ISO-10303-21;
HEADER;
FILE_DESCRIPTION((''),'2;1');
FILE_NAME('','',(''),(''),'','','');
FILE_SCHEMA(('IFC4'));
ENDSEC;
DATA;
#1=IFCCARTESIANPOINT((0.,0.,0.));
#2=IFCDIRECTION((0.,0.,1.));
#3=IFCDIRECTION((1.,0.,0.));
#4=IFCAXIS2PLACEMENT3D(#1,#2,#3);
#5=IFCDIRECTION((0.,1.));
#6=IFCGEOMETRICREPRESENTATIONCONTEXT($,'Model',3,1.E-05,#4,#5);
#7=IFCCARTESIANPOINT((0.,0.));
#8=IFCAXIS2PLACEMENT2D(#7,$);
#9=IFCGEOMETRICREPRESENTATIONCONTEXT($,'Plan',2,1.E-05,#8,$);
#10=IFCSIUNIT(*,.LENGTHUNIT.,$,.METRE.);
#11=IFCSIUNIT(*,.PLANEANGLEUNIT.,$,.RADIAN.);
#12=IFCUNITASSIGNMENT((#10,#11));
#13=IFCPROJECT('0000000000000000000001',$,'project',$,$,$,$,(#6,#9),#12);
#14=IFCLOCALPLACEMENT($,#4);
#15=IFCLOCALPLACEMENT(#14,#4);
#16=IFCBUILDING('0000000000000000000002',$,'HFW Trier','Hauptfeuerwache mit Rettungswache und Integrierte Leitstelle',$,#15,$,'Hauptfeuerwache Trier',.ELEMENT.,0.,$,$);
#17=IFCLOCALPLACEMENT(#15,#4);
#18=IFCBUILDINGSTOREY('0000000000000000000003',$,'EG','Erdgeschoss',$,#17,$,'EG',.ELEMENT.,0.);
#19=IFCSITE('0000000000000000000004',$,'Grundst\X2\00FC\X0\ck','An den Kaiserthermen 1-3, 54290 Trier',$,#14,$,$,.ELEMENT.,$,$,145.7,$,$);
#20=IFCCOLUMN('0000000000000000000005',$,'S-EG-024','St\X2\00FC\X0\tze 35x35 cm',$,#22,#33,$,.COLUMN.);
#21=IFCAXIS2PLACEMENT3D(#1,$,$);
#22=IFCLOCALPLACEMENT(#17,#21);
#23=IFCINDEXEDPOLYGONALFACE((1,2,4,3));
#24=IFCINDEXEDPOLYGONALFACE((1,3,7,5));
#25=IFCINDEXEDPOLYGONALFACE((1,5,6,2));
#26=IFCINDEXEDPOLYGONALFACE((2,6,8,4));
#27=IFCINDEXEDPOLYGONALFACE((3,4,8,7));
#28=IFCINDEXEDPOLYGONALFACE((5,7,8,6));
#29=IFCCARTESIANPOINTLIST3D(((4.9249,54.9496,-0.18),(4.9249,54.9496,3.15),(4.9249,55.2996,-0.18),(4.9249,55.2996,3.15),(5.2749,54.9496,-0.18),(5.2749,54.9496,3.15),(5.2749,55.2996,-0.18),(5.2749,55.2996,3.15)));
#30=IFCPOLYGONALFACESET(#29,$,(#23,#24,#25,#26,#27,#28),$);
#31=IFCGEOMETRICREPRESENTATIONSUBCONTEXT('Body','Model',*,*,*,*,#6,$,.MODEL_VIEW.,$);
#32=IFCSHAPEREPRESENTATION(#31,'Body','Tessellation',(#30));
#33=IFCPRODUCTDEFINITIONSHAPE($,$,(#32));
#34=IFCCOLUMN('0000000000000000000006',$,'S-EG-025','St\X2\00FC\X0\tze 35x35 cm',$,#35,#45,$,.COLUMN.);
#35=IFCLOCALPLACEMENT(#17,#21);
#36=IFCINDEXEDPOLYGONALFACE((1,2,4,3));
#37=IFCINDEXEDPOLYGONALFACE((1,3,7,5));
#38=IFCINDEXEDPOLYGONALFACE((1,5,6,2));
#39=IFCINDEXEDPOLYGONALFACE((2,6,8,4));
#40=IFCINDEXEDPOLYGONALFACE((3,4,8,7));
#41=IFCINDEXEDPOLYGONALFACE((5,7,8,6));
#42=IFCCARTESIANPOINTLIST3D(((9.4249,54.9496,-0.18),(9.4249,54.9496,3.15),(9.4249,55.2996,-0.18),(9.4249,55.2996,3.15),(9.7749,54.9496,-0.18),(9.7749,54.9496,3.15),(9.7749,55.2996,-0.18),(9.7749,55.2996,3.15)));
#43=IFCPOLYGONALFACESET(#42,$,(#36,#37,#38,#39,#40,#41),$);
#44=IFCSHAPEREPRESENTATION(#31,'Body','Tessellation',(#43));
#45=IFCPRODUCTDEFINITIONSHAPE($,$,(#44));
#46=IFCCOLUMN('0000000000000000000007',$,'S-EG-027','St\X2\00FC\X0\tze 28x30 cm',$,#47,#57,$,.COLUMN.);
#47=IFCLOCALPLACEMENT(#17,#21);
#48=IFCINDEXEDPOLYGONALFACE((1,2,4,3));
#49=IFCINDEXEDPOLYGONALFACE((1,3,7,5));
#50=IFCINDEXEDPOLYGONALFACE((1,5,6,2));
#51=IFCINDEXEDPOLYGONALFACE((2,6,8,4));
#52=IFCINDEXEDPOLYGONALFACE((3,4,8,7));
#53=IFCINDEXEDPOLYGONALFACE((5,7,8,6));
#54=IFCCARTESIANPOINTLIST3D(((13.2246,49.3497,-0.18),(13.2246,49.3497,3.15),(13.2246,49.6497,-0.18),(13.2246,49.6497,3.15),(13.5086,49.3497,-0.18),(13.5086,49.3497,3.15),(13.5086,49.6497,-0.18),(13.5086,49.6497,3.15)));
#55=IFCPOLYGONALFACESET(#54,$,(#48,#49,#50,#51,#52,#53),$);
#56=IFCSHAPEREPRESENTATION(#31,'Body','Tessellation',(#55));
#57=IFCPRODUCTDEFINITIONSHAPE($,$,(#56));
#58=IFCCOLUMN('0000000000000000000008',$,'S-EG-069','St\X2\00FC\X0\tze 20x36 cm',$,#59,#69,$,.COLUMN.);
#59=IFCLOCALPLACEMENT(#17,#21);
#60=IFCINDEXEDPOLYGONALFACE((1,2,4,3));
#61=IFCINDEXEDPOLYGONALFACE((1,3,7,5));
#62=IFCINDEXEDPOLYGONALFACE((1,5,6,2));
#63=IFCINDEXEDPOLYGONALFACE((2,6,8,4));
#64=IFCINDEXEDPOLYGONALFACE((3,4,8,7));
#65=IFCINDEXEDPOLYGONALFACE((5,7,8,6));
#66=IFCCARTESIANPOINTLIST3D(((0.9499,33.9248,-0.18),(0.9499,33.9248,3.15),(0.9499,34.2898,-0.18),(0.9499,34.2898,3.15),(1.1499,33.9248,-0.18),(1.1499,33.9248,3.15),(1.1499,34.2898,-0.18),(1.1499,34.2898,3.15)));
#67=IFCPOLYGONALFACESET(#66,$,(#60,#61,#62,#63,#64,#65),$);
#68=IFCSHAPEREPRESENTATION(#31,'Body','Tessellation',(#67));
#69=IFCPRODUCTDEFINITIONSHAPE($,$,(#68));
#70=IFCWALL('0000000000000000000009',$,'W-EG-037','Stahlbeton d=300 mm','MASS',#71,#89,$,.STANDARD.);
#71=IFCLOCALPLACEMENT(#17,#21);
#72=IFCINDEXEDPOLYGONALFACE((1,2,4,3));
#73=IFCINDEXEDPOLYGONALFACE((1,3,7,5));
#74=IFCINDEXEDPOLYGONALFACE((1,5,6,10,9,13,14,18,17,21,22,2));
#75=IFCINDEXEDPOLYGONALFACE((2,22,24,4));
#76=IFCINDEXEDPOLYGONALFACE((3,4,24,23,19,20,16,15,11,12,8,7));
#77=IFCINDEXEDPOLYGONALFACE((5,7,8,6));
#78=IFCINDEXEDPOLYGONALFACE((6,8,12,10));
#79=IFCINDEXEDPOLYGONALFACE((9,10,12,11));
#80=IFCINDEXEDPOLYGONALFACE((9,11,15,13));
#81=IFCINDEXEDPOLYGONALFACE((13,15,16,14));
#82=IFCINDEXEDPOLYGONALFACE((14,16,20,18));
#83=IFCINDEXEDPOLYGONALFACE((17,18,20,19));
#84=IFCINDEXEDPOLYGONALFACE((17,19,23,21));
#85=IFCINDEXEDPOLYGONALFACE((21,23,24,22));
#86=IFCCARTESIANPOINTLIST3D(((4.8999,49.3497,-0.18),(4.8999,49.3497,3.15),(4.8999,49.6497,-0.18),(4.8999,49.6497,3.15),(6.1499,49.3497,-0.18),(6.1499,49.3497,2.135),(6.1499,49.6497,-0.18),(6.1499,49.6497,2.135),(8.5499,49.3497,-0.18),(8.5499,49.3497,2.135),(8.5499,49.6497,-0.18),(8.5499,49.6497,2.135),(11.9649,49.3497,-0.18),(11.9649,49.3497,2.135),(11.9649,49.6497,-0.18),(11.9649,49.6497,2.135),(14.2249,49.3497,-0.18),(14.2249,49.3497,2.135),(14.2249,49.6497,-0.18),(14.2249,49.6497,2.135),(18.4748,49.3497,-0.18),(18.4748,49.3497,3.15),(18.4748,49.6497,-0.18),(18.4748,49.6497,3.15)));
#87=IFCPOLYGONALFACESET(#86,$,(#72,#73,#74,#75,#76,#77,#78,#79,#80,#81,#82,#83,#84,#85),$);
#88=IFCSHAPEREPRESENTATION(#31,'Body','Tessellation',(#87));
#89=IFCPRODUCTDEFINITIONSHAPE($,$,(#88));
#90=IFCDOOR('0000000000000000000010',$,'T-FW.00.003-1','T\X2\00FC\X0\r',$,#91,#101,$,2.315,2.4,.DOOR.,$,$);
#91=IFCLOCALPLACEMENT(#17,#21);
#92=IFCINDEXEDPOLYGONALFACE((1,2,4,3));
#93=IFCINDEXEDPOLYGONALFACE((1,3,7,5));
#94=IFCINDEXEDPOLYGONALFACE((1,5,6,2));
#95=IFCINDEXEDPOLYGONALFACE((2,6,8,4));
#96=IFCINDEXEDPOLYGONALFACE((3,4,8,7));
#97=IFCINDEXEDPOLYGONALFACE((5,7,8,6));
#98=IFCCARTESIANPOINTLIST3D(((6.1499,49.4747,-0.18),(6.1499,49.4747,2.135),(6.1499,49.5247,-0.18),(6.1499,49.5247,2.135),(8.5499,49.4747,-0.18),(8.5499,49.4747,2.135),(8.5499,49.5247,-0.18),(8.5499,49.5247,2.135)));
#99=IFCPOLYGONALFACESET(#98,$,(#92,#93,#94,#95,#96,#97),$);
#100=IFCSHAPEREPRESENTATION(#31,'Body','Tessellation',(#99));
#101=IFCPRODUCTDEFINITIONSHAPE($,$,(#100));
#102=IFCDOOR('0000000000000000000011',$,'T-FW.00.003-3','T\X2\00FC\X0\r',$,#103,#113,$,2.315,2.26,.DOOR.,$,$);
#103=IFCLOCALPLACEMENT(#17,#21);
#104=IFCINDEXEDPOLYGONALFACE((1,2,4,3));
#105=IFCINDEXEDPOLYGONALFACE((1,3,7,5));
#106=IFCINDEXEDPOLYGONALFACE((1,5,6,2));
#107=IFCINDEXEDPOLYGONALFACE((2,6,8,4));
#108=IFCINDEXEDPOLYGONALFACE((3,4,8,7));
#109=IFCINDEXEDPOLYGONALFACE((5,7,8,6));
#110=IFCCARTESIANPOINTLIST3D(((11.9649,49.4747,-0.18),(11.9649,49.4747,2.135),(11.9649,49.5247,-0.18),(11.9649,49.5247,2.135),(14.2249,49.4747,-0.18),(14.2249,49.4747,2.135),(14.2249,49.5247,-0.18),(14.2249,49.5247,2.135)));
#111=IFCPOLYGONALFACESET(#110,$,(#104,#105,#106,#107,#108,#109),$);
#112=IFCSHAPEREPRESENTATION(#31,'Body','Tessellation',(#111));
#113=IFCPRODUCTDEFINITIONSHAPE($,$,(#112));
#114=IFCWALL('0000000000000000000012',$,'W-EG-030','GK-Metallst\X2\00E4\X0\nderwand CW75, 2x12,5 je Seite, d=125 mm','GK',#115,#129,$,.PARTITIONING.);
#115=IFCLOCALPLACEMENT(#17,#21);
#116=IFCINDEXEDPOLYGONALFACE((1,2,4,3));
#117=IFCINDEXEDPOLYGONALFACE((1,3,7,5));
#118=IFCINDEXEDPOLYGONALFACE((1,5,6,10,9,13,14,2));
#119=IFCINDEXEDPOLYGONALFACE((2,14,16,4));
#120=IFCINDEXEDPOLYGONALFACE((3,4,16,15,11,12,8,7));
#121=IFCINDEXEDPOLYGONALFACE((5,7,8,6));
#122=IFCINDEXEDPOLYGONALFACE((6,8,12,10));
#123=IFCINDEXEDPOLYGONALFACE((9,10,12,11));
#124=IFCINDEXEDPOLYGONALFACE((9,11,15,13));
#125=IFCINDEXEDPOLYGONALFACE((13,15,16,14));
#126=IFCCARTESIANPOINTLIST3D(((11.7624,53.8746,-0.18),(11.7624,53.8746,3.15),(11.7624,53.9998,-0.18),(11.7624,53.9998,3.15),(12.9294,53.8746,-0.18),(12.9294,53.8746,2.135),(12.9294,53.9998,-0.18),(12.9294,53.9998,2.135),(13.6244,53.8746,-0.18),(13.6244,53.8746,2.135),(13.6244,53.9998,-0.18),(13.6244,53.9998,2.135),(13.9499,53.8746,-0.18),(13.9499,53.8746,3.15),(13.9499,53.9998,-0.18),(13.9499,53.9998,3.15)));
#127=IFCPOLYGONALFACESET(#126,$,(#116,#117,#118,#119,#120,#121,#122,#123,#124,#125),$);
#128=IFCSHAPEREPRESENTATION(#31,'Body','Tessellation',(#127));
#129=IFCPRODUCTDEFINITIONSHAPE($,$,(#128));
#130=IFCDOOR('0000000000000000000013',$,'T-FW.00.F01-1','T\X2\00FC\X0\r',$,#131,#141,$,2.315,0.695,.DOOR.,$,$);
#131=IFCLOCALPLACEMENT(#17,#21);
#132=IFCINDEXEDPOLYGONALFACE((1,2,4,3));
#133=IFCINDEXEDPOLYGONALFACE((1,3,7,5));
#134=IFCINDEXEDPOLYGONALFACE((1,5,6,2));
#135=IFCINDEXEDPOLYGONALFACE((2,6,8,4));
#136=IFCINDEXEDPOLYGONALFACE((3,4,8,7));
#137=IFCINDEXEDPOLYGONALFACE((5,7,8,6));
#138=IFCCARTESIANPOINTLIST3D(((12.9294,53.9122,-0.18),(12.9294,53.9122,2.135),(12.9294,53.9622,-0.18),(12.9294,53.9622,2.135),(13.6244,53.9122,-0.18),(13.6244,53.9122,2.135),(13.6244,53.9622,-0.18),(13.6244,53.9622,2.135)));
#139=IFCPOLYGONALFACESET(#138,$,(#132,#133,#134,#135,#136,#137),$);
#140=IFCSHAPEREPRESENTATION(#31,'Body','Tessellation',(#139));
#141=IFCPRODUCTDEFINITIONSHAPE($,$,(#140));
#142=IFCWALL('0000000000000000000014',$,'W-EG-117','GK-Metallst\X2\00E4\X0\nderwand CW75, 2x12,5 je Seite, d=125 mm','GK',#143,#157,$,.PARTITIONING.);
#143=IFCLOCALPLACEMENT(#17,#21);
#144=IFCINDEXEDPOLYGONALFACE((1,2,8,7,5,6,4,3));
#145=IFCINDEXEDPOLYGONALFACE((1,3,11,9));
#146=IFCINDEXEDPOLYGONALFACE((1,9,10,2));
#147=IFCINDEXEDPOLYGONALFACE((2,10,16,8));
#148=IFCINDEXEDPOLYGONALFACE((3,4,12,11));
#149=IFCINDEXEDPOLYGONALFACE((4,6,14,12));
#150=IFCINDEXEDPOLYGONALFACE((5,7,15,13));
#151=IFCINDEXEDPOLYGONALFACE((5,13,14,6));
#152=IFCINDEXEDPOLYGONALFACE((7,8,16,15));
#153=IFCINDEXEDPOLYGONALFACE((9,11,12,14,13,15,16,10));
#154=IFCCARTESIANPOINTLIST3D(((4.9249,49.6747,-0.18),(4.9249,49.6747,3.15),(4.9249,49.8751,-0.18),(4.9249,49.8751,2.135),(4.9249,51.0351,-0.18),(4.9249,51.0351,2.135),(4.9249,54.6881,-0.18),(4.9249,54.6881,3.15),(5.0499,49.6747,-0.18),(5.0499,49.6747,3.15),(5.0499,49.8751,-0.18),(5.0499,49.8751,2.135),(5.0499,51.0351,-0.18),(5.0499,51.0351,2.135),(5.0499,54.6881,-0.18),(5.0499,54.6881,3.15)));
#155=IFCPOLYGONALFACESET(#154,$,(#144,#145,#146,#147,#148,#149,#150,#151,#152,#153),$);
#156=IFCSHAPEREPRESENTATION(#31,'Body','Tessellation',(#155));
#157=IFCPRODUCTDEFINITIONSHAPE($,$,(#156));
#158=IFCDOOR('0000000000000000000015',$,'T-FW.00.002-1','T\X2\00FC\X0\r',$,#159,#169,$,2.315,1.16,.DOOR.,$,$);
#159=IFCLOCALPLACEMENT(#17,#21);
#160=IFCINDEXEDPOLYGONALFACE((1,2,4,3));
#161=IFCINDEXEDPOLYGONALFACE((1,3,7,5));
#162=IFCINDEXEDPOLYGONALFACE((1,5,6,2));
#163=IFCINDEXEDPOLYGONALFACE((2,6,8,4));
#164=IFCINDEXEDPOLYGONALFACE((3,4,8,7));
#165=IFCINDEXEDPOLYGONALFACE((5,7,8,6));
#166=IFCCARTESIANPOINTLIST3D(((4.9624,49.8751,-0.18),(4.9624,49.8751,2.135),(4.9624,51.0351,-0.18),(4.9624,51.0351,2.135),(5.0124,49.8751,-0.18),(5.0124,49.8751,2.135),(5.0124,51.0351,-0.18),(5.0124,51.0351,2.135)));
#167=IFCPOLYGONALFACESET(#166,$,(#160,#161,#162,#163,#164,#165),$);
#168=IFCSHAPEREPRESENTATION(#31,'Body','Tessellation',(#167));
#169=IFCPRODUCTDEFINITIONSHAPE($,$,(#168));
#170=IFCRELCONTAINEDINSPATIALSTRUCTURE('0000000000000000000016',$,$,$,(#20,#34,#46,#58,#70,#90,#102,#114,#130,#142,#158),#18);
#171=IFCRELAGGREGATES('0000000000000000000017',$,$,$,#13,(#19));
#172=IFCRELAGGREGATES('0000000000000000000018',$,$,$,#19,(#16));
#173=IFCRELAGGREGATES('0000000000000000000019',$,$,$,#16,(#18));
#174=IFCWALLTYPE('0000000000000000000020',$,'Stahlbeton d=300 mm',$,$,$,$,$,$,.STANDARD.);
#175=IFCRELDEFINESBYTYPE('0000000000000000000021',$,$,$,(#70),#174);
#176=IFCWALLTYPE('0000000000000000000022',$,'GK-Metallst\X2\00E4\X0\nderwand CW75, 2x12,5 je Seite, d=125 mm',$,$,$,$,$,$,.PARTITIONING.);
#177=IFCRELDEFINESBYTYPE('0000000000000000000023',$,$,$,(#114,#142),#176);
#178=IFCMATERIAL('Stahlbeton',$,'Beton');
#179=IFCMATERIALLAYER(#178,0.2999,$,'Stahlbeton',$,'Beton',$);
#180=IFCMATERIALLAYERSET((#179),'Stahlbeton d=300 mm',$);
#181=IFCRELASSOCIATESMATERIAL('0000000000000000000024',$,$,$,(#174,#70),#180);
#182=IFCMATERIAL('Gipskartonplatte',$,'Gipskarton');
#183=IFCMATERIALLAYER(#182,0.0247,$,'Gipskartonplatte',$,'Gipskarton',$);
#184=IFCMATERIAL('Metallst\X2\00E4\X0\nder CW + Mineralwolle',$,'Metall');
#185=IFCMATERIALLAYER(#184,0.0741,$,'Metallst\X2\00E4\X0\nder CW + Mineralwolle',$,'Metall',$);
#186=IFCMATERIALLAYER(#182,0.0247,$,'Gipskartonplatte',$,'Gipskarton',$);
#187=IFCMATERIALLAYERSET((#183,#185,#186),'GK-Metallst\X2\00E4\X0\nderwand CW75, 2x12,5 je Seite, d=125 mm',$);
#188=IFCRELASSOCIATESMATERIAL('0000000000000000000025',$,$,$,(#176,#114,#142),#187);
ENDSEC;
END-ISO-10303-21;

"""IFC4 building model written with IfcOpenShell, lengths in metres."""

from ifc_helpers import new_model, si_unit, direction, frame, frame_2d, origin_with_axes, origin_2d, place, context, subcontext, project, spatial, rectangle, extrude, material, layer, layer_set, layer_usage, type_object, element, fill, save


model = new_model("IFC4")

# Units and contexts
model_context = context("Model", 3, precision=1e-05, world=origin_with_axes(), true_north=direction((0.0, 1.0)))
plan_context = context("Plan", 2, precision=1e-05, world=origin_2d())
body_context = subcontext(model_context, "Body", "Model", "MODEL_VIEW")
ifc_project = project(units=[si_unit("LENGTHUNIT", "METRE"), si_unit("PLANEANGLEUNIT", "RADIAN")], contexts=[model_context, plan_context])

# Site, building, storey
site_placement = place(None, origin_with_axes())
site = spatial("IfcSite", under=ifc_project, at=site_placement, Name="Grundstück", Description="An den Kaiserthermen 1-3, 54290 Trier", CompositionType="ELEMENT", RefElevation=145.7)
building_placement = place(site_placement, origin_with_axes())
building = spatial("IfcBuilding", under=site, at=building_placement, Name="HFW Trier", Description="Hauptfeuerwache mit Rettungswache und Integrierte Leitstelle", LongName="Hauptfeuerwache Trier", CompositionType="ELEMENT", ElevationOfRefHeight=0.0)
storey_placement = place(building_placement, origin_with_axes())
storey = spatial("IfcBuildingStorey", under=building, at=storey_placement, Name="EG", Description="Erdgeschoss", LongName="EG", CompositionType="ELEMENT", Elevation=0.0)

# Columns
for number, where, z_axis, x_axis, name in (
    (1, (4.9249, 55.1246, -0.18), (0.0, 0.0, 1.0), (1.0, 0.0, 0.0), "S-EG-024"),
    (2, (9.4249, 55.1246, -0.18), (0.0, 0.0, 1.0), (1.0, 0.0, 0.0), "S-EG-025"),
):
    element("IfcColumn", number, at=place(storey_placement, frame(where, z_axis=z_axis, x_axis=x_axis)), inside=storey, Name=name, Description="Stütze 35x35 cm", PredefinedType="COLUMN", context=body_context, shape_type="SweptSolid", body=[
        extrude(rectangle(XDim=0.35, YDim=0.35, at=frame_2d((0.175, 0.0))), origin_with_axes(), (0.0, 0.0, 1.0), 3.33),
    ])
column_1_placement = place(storey_placement, frame((13.2246, 49.4997, -0.18), z_axis=(0.0, 0.0, 1.0), x_axis=(1.0, 0.0, 0.0)))
element("IfcColumn", 3, at=column_1_placement, inside=storey, Name="S-EG-027", Description="Stütze 28x30 cm", PredefinedType="COLUMN", context=body_context, shape_type="SweptSolid", body=[
    extrude(rectangle(XDim=0.284, YDim=0.3, at=frame_2d((0.142, 0.0))), origin_with_axes(), (0.0, 0.0, 1.0), 3.33),
])
column_2_placement = place(storey_placement, frame((0.9499, 34.1073, -0.18), z_axis=(0.0, 0.0, 1.0), x_axis=(1.0, 0.0, 0.0)))
element("IfcColumn", 4, at=column_2_placement, inside=storey, Name="S-EG-069", Description="Stütze 20x36 cm", PredefinedType="COLUMN", context=body_context, shape_type="SweptSolid", body=[
    extrude(rectangle(XDim=0.2, YDim=0.365, at=frame_2d((0.1, 0.0))), origin_with_axes(), (0.0, 0.0, 1.0), 3.33),
])

# Wall, openings, doors
ifc_material_1 = material(Name="Stahlbeton", Category="Beton")
ifc_layer_1 = layer(ifc_material_1, 0.2999, Name="Stahlbeton", Category="Beton")
ifc_layer_set_1 = layer_set([ifc_layer_1], Name="Stahlbeton d=300 mm")
ifc_layer_usage_1 = layer_usage(ifc_layer_set_1, "AXIS2", "POSITIVE", -0.15)
wall_type_1 = type_object("IfcWallType", Name="Stahlbeton d=300 mm", PredefinedType="STANDARD", material=ifc_layer_set_1)
wall_1_placement = place(storey_placement, frame((4.8999, 49.4997, -0.18), z_axis=(0.0, 0.0, 1.0), x_axis=(1.0, 0.0, 0.0)))
wall_1 = element("IfcWall", 5, at=wall_1_placement, inside=storey, type_object=wall_type_1, material=ifc_layer_usage_1, Name="W-EG-037", Description="Stahlbeton d=300 mm", ObjectType="MASS", PredefinedType="STANDARD", context=body_context, shape_type="SweptSolid", body=[
    extrude(rectangle(XDim=13.5749, YDim=0.3, at=frame_2d((6.7874, 0.0))), origin_with_axes(), (0.0, 0.0, 1.0), 3.33),
])
opening_1_placement = place(wall_1_placement, frame((1.25, 0.0, 0.0), z_axis=(0.0, 0.0, 1.0), x_axis=(1.0, 0.0, 0.0)))
opening_1 = element("IfcOpeningElement", 6, at=opening_1_placement, cuts=wall_1, PredefinedType="OPENING", context=body_context, shape_type="SweptSolid", body=[
    extrude(rectangle(XDim=2.4, YDim=0.4, at=frame_2d((1.2, 0.0))), origin_with_axes(), (0.0, 0.0, 1.0), 2.315),
])
opening_2_placement = place(wall_1_placement, frame((7.065, 0.0, 0.0), z_axis=(0.0, 0.0, 1.0), x_axis=(1.0, 0.0, 0.0)))
opening_2 = element("IfcOpeningElement", 7, at=opening_2_placement, cuts=wall_1, PredefinedType="OPENING", context=body_context, shape_type="SweptSolid", body=[
    extrude(rectangle(XDim=2.26, YDim=0.4, at=frame_2d((1.13, 0.0))), origin_with_axes(), (0.0, 0.0, 1.0), 2.315),
])
door_1_placement = place(wall_1_placement, frame((1.25, 0.0, 0.0), z_axis=(0.0, 0.0, 1.0), x_axis=(1.0, 0.0, 0.0)))
door_1 = element("IfcDoor", 8, at=door_1_placement, inside=storey, Name="T-FW.00.003-1", Description="Tür", OverallHeight=2.315, OverallWidth=2.4, PredefinedType="DOOR", context=body_context, shape_type="SweptSolid", body=[
    extrude(rectangle(XDim=2.4, YDim=0.05, at=frame_2d((1.2, 0.0))), origin_with_axes(), (0.0, 0.0, 1.0), 2.315),
])
fill(opening_1, door_1)
door_2_placement = place(wall_1_placement, frame((7.065, 0.0, 0.0), z_axis=(0.0, 0.0, 1.0), x_axis=(1.0, 0.0, 0.0)))
door_2 = element("IfcDoor", 9, at=door_2_placement, inside=storey, Name="T-FW.00.003-3", Description="Tür", OverallHeight=2.315, OverallWidth=2.26, PredefinedType="DOOR", context=body_context, shape_type="SweptSolid", body=[
    extrude(rectangle(XDim=2.26, YDim=0.05, at=frame_2d((1.13, 0.0))), origin_with_axes(), (0.0, 0.0, 1.0), 2.315),
])
fill(opening_2, door_2)

# Walls, openings, doors
ifc_material_2 = material(Name="Gipskartonplatte", Category="Gipskarton")
ifc_layer_2 = layer(ifc_material_2, 0.0247, Name="Gipskartonplatte", Category="Gipskarton")
ifc_material_3 = material(Name="Metallständer CW + Mineralwolle", Category="Metall")
ifc_layer_3 = layer(ifc_material_3, 0.0741, Name="Metallständer CW + Mineralwolle", Category="Metall")
ifc_layer_4 = layer(ifc_material_2, 0.0247, Name="Gipskartonplatte", Category="Gipskarton")
ifc_layer_set_2 = layer_set([ifc_layer_2, ifc_layer_3, ifc_layer_4], Name="GK-Metallständerwand CW75, 2x12,5 je Seite, d=125 mm")
ifc_layer_usage_2 = layer_usage(ifc_layer_set_2, "AXIS2", "POSITIVE", -0.0625)
wall_type_2 = type_object("IfcWallType", Name="GK-Metallständerwand CW75, 2x12,5 je Seite, d=125 mm", PredefinedType="PARTITIONING", material=ifc_layer_set_2)
wall_2_placement = place(storey_placement, frame((11.7624, 53.9372, -0.18), z_axis=(0.0, 0.0, 1.0), x_axis=(1.0, 0.0, 0.0)))
wall_2 = element("IfcWall", 10, at=wall_2_placement, inside=storey, type_object=wall_type_2, material=ifc_layer_usage_2, Name="W-EG-030", Description="GK-Metallständerwand CW75, 2x12,5 je Seite, d=125 mm", ObjectType="GK", PredefinedType="PARTITIONING", context=body_context, shape_type="SweptSolid", body=[
    extrude(rectangle(XDim=2.1875, YDim=0.1251, at=frame_2d((1.0938, 0.0))), origin_with_axes(), (0.0, 0.0, 1.0), 3.33),
])
opening_3_placement = place(wall_2_placement, frame((1.167, 0.0, 0.0), z_axis=(0.0, 0.0, 1.0), x_axis=(1.0, 0.0, 0.0)))
opening_3 = element("IfcOpeningElement", 11, at=opening_3_placement, cuts=wall_2, PredefinedType="OPENING", context=body_context, shape_type="SweptSolid", body=[
    extrude(rectangle(XDim=0.695, YDim=0.2251, at=frame_2d((0.3475, 0.0))), origin_with_axes(), (0.0, 0.0, 1.0), 2.315),
])
door_3_placement = place(wall_2_placement, frame((1.167, 0.0, 0.0), z_axis=(0.0, 0.0, 1.0), x_axis=(1.0, 0.0, 0.0)))
door_3 = element("IfcDoor", 12, at=door_3_placement, inside=storey, Name="T-FW.00.F01-1", Description="Tür", OverallHeight=2.315, OverallWidth=0.695, PredefinedType="DOOR", context=body_context, shape_type="SweptSolid", body=[
    extrude(rectangle(XDim=0.695, YDim=0.05, at=frame_2d((0.3475, 0.0))), origin_with_axes(), (0.0, 0.0, 1.0), 2.315),
])
fill(opening_3, door_3)
ifc_layer_usage_3 = layer_usage(ifc_layer_set_2, "AXIS2", "POSITIVE", -0.0625)
wall_3_placement = place(storey_placement, frame((4.9874, 54.6881, -0.18), z_axis=(0.0, 0.0, 1.0), x_axis=(0.0, -1.0, 0.0)))
wall_3 = element("IfcWall", 13, at=wall_3_placement, inside=storey, type_object=wall_type_2, material=ifc_layer_usage_3, Name="W-EG-117", Description="GK-Metallständerwand CW75, 2x12,5 je Seite, d=125 mm", ObjectType="GK", PredefinedType="PARTITIONING", context=body_context, shape_type="SweptSolid", body=[
    extrude(rectangle(XDim=5.0134, YDim=0.125, at=frame_2d((2.5067, 0.0))), origin_with_axes(), (0.0, 0.0, 1.0), 3.33),
])
opening_4_placement = place(wall_3_placement, frame((3.653, 0.0, 0.0), z_axis=(0.0, 0.0, 1.0), x_axis=(1.0, 0.0, 0.0)))
opening_4 = element("IfcOpeningElement", 14, at=opening_4_placement, cuts=wall_3, PredefinedType="OPENING", context=body_context, shape_type="SweptSolid", body=[
    extrude(rectangle(XDim=1.16, YDim=0.225, at=frame_2d((0.58, 0.0))), origin_with_axes(), (0.0, 0.0, 1.0), 2.315),
])
door_4_placement = place(wall_3_placement, frame((3.653, 0.0, 0.0), z_axis=(0.0, 0.0, 1.0), x_axis=(1.0, 0.0, 0.0)))
door_4 = element("IfcDoor", 15, at=door_4_placement, inside=storey, Name="T-FW.00.002-1", Description="Tür", OverallHeight=2.315, OverallWidth=1.16, PredefinedType="DOOR", context=body_context, shape_type="SweptSolid", body=[
    extrude(rectangle(XDim=1.16, YDim=0.05, at=frame_2d((0.58, 0.0))), origin_with_axes(), (0.0, 0.0, 1.0), 2.315),
])
fill(opening_4, door_4)

save(model, "model.ifc")
